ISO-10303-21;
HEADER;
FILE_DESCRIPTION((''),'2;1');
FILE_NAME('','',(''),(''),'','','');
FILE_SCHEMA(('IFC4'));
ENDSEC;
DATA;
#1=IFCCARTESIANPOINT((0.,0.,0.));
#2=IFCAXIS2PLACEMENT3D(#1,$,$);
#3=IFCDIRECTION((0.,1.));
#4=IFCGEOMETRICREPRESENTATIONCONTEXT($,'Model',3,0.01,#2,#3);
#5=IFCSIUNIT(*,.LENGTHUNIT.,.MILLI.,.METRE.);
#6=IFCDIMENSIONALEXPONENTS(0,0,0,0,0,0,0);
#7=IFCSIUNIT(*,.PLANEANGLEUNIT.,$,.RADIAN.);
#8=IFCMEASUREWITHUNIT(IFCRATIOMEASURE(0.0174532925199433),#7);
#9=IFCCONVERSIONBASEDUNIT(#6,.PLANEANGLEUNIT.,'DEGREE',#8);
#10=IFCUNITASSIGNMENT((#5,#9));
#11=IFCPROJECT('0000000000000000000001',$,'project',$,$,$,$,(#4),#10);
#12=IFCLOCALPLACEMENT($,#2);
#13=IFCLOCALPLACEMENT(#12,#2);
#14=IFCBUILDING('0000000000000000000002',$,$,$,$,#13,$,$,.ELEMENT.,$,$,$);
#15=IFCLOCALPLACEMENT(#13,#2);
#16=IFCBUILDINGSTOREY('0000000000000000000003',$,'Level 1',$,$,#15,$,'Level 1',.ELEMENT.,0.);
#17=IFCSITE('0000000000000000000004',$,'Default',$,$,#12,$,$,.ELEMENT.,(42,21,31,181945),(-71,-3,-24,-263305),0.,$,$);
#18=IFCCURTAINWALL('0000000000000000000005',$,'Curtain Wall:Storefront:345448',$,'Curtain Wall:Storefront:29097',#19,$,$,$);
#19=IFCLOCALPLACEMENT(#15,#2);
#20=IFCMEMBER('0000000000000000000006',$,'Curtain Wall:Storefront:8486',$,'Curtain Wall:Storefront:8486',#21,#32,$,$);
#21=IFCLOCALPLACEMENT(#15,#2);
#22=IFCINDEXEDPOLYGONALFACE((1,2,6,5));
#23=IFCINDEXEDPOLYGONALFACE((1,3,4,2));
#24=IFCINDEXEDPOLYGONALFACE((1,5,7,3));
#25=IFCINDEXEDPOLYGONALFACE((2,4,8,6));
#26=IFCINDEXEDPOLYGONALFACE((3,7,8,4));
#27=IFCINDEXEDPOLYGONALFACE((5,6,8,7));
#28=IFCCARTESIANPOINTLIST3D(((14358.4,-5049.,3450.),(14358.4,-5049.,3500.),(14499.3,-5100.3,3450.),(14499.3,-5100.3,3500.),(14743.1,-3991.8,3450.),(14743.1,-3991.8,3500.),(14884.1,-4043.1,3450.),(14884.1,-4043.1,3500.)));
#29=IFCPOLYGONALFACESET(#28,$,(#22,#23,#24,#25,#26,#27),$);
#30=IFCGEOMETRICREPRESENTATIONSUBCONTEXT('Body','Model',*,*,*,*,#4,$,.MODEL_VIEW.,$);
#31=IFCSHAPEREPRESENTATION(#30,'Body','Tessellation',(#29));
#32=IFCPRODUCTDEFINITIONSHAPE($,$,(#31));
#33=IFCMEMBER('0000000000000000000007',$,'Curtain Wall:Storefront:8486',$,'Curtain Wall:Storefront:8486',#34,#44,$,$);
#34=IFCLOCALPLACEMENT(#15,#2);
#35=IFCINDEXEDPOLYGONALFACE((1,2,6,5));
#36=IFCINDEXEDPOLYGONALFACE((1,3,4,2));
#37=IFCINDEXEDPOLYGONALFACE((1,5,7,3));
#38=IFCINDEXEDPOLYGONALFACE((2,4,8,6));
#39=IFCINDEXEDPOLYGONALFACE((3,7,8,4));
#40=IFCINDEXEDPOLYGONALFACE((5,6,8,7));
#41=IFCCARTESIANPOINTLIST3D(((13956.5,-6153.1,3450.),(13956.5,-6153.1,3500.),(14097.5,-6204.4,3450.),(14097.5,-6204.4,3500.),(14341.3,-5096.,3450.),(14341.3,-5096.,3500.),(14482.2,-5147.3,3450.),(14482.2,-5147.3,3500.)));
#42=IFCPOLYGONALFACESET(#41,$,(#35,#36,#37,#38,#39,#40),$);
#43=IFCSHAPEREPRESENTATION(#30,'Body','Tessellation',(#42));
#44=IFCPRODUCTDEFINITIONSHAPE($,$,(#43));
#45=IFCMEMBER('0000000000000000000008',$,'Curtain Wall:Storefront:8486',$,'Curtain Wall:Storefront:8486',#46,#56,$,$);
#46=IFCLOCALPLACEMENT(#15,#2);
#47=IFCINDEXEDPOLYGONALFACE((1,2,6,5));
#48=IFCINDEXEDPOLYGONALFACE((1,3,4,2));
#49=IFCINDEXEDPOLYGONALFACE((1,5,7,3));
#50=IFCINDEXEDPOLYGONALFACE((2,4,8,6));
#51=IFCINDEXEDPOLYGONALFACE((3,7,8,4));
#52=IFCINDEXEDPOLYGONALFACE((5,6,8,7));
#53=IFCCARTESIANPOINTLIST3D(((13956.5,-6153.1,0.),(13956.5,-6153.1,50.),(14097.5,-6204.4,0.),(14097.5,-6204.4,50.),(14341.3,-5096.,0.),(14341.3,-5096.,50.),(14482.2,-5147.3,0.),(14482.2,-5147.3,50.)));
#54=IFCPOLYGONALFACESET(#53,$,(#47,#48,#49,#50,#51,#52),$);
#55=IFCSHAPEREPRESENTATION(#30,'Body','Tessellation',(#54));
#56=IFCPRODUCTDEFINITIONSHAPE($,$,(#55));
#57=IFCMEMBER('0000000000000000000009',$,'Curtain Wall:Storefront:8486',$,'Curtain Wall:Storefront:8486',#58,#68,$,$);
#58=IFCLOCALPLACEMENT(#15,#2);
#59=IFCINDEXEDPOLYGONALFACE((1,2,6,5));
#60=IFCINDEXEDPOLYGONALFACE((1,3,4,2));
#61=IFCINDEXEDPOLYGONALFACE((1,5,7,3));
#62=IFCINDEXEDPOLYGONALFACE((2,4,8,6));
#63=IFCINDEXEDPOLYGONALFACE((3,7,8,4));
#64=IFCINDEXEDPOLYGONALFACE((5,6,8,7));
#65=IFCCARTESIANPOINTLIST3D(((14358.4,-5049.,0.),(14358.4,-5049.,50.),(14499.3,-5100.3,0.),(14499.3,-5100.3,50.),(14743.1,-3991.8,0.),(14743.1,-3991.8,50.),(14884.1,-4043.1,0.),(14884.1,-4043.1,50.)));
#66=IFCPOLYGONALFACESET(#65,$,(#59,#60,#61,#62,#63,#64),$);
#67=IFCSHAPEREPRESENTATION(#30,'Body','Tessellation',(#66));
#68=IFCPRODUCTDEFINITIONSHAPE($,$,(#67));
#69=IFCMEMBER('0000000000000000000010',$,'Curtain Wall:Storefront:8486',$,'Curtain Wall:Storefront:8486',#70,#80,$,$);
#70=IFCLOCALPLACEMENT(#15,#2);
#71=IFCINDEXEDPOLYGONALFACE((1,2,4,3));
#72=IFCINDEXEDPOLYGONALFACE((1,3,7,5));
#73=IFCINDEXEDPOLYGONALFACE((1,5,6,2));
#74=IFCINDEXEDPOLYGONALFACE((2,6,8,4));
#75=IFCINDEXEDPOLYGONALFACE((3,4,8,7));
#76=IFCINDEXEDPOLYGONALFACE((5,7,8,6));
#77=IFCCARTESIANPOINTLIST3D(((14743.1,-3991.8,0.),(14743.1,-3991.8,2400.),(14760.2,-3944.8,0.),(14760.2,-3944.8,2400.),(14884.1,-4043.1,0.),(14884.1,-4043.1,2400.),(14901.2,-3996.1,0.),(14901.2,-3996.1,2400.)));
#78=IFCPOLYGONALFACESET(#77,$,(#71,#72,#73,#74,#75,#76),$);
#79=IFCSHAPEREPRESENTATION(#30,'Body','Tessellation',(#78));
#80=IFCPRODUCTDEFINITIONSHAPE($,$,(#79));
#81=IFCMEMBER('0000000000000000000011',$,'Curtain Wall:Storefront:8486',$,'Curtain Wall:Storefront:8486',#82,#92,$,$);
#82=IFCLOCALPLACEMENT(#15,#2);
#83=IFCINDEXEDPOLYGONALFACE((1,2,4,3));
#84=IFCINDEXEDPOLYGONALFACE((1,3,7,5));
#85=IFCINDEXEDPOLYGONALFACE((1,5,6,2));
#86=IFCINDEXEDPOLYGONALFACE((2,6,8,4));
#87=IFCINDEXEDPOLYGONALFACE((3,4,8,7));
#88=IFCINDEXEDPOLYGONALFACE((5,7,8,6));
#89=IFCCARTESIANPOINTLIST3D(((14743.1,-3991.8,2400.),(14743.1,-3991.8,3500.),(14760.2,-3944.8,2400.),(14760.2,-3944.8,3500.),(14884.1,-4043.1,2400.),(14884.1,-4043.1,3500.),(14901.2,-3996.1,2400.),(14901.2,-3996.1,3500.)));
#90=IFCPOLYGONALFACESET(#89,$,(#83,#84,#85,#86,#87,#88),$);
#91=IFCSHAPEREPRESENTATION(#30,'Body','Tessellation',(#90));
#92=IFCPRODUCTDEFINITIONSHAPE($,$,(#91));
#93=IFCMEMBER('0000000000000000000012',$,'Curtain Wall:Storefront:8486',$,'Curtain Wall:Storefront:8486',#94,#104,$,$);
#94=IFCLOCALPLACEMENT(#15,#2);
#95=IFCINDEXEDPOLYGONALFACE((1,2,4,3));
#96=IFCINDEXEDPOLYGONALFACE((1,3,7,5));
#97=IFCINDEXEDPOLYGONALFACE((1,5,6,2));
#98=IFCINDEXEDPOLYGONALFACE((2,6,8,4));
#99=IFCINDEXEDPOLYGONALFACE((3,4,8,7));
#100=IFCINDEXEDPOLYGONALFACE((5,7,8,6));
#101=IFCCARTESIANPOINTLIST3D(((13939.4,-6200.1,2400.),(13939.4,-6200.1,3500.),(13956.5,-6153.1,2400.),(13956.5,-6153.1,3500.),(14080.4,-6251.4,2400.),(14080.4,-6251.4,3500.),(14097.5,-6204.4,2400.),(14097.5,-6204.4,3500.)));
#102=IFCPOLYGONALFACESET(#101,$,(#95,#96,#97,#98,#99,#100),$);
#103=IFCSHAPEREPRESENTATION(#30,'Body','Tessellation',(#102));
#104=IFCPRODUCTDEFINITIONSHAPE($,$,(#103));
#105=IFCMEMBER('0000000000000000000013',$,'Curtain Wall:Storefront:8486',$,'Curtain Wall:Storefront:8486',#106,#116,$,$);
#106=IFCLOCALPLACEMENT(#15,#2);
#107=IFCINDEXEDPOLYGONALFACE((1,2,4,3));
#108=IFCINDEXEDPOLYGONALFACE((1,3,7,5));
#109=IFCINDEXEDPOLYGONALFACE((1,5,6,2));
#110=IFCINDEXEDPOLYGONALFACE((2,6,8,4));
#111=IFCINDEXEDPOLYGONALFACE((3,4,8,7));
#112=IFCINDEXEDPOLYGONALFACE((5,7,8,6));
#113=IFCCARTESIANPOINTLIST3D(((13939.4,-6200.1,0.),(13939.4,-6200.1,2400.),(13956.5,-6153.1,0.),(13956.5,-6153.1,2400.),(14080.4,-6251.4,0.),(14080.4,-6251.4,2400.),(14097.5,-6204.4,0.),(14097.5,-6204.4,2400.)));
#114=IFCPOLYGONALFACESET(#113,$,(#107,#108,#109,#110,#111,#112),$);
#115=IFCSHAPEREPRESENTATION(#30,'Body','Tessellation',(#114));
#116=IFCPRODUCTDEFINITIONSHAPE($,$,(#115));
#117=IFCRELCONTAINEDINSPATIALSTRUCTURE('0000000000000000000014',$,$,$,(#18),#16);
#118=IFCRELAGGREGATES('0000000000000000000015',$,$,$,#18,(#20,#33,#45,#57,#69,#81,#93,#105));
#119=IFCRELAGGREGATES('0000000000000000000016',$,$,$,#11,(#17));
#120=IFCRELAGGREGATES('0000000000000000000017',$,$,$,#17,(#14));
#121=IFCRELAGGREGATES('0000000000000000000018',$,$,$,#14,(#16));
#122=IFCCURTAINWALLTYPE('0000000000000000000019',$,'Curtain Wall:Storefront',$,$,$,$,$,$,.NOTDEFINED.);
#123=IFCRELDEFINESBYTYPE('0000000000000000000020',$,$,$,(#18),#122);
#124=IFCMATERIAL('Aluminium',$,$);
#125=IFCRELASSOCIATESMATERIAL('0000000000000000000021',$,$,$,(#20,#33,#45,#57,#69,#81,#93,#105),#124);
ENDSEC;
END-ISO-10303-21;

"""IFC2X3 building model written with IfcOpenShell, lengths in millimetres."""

from ifc_helpers import new_model, entity, si_unit, converted_unit, direction, frame, frame_2d, origin, origin_2d_with_axis, place, context, subcontext, project, spatial, rectangle, extrude, material, type_object, element, aggregate, save


model = new_model("IFC2X3")

# Units and contexts
model_context = context("Model", 3, precision=0.01, world=origin(), true_north=direction((0.0, 1.0)))
body_context = subcontext(model_context, "Body", "Model", "MODEL_VIEW")
ifc_project = project(units=[si_unit("LENGTHUNIT", "METRE", prefix="MILLI"), converted_unit("PLANEANGLEUNIT", "DEGREE", entity("IfcRatioMeasure", 0.0174532925199433), si_unit("PLANEANGLEUNIT", "RADIAN"), dimensions=[0, 0, 0, 0, 0, 0, 0])], contexts=[model_context])

# Site, building, storey
site_placement = place(None, origin())
site = spatial("IfcSite", under=ifc_project, at=site_placement, Name="Default", CompositionType="ELEMENT", RefLatitude=(42, 21, 31, 181945), RefLongitude=(-71, -3, -24, -263305), RefElevation=0.0)
building_placement = place(site_placement, origin())
building = spatial("IfcBuilding", under=site, at=building_placement, CompositionType="ELEMENT")
storey_placement = place(building_placement, origin())
storey = spatial("IfcBuildingStorey", under=building, at=storey_placement, Name="Level 1", LongName="Level 1", CompositionType="ELEMENT", Elevation=0.0)

# Curtain wall, members
curtain_wall_type = type_object("IfcCurtainWallType", Name="Curtain Wall:Storefront", PredefinedType="NOTDEFINED")
curtain_wall_placement = place(storey_placement, origin())
curtain_wall = element("IfcCurtainWall", 1, at=curtain_wall_placement, inside=storey, type_object=curtain_wall_type, Name="Curtain Wall:Storefront:345448", ObjectType="Curtain Wall:Storefront:29097")
ifc_material = material(Name="Aluminium")
member_1_placement = place(curtain_wall_placement, origin())
member_1 = element("IfcMember", 2, at=member_1_placement, material=ifc_material, Name="Curtain Wall:Storefront:8486", ObjectType="Curtain Wall:Storefront:8486", context=body_context, shape_type="SweptSolid", body=[
    extrude(rectangle(XDim=50.0, YDim=150.0, at=frame_2d((0.0, 0.0), x_axis=(1.0, 0.0))), frame((14813.6, -4017.5, 3475.0), z_axis=(-0.34202, -0.939693, 0.0), x_axis=(0.0, 0.0, -1.0)), (0.0, 0.0, 1.0), 1125.0),
])
member_2_placement = place(curtain_wall_placement, origin())
member_2 = element("IfcMember", 3, at=member_2_placement, material=ifc_material, Name="Curtain Wall:Storefront:8486", ObjectType="Curtain Wall:Storefront:8486", context=body_context, shape_type="SweptSolid", body=[
    extrude(rectangle(XDim=50.0, YDim=150.0, at=frame_2d((0.0, 0.0), x_axis=(1.0, 0.0))), frame((14411.8, -5121.6, 3475.0), z_axis=(-0.34202, -0.939693, 0.0), x_axis=(0.0, 0.0, -1.0)), (0.0, 0.0, 1.0), 1125.0),
])
member_3_placement = place(curtain_wall_placement, origin())
member_3 = element("IfcMember", 4, at=member_3_placement, material=ifc_material, Name="Curtain Wall:Storefront:8486", ObjectType="Curtain Wall:Storefront:8486", context=body_context, shape_type="SweptSolid", body=[
    extrude(rectangle(XDim=50.0, YDim=150.0, at=frame_2d((0.0, 0.0), x_axis=(1.0, 0.0))), frame((14027.0, -6178.8, 25.0), z_axis=(0.34202, 0.939693, 0.0), x_axis=(0.0, 0.0, -1.0)), (0.0, 0.0, 1.0), 1125.0),
])
member_4_placement = place(curtain_wall_placement, origin())
member_4 = element("IfcMember", 5, at=member_4_placement, material=ifc_material, Name="Curtain Wall:Storefront:8486", ObjectType="Curtain Wall:Storefront:8486", context=body_context, shape_type="SweptSolid", body=[
    extrude(rectangle(XDim=50.0, YDim=150.0, at=origin_2d_with_axis()), frame((14428.9, -5074.6, 25.0), z_axis=(0.34202, 0.939693, 0.0), x_axis=(0.0, 0.0, -1.0)), (0.0, 0.0, 1.0), 1125.0),
])
member_5_placement = place(curtain_wall_placement, origin())
member_5 = element("IfcMember", 6, at=member_5_placement, material=ifc_material, Name="Curtain Wall:Storefront:8486", ObjectType="Curtain Wall:Storefront:8486", context=body_context, shape_type="SweptSolid", body=[
    extrude(rectangle(XDim=50.0, YDim=150.0, at=frame_2d((0.0, 0.0), x_axis=(1.0, 0.0))), frame((14822.2, -3994.0, 0.0), z_axis=(0.0, 0.0, 1.0), x_axis=(0.34202, 0.939693, 0.0)), (0.0, 0.0, 1.0), 2400.0),
])
member_6_placement = place(curtain_wall_placement, origin())
member_6 = element("IfcMember", 7, at=member_6_placement, material=ifc_material, Name="Curtain Wall:Storefront:8486", ObjectType="Curtain Wall:Storefront:8486", context=body_context, shape_type="SweptSolid", body=[
    extrude(rectangle(XDim=50.0, YDim=150.0, at=frame_2d((0.0, 0.0), x_axis=(1.0, 0.0))), frame((14822.2, -3994.0, 2400.0), z_axis=(0.0, 0.0, 1.0), x_axis=(0.34202, 0.939693, 0.0)), (0.0, 0.0, 1.0), 1100.0),
])
member_7_placement = place(curtain_wall_placement, origin())
member_7 = element("IfcMember", 8, at=member_7_placement, material=ifc_material, Name="Curtain Wall:Storefront:8486", ObjectType="Curtain Wall:Storefront:8486", context=body_context, shape_type="SweptSolid", body=[
    extrude(rectangle(XDim=50.0, YDim=150.0, at=origin_2d_with_axis()), frame((14018.4, -6202.3, 3500.0), z_axis=(0.0, 0.0, -1.0), x_axis=(-0.34202, -0.939693, 0.0)), (0.0, 0.0, 1.0), 1100.0),
])
member_8_placement = place(curtain_wall_placement, origin())
member_8 = element("IfcMember", 9, at=member_8_placement, material=ifc_material, Name="Curtain Wall:Storefront:8486", ObjectType="Curtain Wall:Storefront:8486", context=body_context, shape_type="SweptSolid", body=[
    extrude(rectangle(XDim=50.0, YDim=150.0, at=origin_2d_with_axis()), frame((14018.4, -6202.3, 2400.0), z_axis=(0.0, 0.0, -1.0), x_axis=(-0.34202, -0.939693, 0.0)), (0.0, 0.0, 1.0), 2400.0),
])
aggregate(curtain_wall, [member_1, member_2, member_3, member_4, member_5, member_6, member_7, member_8])

save(model, "model.ifc")
